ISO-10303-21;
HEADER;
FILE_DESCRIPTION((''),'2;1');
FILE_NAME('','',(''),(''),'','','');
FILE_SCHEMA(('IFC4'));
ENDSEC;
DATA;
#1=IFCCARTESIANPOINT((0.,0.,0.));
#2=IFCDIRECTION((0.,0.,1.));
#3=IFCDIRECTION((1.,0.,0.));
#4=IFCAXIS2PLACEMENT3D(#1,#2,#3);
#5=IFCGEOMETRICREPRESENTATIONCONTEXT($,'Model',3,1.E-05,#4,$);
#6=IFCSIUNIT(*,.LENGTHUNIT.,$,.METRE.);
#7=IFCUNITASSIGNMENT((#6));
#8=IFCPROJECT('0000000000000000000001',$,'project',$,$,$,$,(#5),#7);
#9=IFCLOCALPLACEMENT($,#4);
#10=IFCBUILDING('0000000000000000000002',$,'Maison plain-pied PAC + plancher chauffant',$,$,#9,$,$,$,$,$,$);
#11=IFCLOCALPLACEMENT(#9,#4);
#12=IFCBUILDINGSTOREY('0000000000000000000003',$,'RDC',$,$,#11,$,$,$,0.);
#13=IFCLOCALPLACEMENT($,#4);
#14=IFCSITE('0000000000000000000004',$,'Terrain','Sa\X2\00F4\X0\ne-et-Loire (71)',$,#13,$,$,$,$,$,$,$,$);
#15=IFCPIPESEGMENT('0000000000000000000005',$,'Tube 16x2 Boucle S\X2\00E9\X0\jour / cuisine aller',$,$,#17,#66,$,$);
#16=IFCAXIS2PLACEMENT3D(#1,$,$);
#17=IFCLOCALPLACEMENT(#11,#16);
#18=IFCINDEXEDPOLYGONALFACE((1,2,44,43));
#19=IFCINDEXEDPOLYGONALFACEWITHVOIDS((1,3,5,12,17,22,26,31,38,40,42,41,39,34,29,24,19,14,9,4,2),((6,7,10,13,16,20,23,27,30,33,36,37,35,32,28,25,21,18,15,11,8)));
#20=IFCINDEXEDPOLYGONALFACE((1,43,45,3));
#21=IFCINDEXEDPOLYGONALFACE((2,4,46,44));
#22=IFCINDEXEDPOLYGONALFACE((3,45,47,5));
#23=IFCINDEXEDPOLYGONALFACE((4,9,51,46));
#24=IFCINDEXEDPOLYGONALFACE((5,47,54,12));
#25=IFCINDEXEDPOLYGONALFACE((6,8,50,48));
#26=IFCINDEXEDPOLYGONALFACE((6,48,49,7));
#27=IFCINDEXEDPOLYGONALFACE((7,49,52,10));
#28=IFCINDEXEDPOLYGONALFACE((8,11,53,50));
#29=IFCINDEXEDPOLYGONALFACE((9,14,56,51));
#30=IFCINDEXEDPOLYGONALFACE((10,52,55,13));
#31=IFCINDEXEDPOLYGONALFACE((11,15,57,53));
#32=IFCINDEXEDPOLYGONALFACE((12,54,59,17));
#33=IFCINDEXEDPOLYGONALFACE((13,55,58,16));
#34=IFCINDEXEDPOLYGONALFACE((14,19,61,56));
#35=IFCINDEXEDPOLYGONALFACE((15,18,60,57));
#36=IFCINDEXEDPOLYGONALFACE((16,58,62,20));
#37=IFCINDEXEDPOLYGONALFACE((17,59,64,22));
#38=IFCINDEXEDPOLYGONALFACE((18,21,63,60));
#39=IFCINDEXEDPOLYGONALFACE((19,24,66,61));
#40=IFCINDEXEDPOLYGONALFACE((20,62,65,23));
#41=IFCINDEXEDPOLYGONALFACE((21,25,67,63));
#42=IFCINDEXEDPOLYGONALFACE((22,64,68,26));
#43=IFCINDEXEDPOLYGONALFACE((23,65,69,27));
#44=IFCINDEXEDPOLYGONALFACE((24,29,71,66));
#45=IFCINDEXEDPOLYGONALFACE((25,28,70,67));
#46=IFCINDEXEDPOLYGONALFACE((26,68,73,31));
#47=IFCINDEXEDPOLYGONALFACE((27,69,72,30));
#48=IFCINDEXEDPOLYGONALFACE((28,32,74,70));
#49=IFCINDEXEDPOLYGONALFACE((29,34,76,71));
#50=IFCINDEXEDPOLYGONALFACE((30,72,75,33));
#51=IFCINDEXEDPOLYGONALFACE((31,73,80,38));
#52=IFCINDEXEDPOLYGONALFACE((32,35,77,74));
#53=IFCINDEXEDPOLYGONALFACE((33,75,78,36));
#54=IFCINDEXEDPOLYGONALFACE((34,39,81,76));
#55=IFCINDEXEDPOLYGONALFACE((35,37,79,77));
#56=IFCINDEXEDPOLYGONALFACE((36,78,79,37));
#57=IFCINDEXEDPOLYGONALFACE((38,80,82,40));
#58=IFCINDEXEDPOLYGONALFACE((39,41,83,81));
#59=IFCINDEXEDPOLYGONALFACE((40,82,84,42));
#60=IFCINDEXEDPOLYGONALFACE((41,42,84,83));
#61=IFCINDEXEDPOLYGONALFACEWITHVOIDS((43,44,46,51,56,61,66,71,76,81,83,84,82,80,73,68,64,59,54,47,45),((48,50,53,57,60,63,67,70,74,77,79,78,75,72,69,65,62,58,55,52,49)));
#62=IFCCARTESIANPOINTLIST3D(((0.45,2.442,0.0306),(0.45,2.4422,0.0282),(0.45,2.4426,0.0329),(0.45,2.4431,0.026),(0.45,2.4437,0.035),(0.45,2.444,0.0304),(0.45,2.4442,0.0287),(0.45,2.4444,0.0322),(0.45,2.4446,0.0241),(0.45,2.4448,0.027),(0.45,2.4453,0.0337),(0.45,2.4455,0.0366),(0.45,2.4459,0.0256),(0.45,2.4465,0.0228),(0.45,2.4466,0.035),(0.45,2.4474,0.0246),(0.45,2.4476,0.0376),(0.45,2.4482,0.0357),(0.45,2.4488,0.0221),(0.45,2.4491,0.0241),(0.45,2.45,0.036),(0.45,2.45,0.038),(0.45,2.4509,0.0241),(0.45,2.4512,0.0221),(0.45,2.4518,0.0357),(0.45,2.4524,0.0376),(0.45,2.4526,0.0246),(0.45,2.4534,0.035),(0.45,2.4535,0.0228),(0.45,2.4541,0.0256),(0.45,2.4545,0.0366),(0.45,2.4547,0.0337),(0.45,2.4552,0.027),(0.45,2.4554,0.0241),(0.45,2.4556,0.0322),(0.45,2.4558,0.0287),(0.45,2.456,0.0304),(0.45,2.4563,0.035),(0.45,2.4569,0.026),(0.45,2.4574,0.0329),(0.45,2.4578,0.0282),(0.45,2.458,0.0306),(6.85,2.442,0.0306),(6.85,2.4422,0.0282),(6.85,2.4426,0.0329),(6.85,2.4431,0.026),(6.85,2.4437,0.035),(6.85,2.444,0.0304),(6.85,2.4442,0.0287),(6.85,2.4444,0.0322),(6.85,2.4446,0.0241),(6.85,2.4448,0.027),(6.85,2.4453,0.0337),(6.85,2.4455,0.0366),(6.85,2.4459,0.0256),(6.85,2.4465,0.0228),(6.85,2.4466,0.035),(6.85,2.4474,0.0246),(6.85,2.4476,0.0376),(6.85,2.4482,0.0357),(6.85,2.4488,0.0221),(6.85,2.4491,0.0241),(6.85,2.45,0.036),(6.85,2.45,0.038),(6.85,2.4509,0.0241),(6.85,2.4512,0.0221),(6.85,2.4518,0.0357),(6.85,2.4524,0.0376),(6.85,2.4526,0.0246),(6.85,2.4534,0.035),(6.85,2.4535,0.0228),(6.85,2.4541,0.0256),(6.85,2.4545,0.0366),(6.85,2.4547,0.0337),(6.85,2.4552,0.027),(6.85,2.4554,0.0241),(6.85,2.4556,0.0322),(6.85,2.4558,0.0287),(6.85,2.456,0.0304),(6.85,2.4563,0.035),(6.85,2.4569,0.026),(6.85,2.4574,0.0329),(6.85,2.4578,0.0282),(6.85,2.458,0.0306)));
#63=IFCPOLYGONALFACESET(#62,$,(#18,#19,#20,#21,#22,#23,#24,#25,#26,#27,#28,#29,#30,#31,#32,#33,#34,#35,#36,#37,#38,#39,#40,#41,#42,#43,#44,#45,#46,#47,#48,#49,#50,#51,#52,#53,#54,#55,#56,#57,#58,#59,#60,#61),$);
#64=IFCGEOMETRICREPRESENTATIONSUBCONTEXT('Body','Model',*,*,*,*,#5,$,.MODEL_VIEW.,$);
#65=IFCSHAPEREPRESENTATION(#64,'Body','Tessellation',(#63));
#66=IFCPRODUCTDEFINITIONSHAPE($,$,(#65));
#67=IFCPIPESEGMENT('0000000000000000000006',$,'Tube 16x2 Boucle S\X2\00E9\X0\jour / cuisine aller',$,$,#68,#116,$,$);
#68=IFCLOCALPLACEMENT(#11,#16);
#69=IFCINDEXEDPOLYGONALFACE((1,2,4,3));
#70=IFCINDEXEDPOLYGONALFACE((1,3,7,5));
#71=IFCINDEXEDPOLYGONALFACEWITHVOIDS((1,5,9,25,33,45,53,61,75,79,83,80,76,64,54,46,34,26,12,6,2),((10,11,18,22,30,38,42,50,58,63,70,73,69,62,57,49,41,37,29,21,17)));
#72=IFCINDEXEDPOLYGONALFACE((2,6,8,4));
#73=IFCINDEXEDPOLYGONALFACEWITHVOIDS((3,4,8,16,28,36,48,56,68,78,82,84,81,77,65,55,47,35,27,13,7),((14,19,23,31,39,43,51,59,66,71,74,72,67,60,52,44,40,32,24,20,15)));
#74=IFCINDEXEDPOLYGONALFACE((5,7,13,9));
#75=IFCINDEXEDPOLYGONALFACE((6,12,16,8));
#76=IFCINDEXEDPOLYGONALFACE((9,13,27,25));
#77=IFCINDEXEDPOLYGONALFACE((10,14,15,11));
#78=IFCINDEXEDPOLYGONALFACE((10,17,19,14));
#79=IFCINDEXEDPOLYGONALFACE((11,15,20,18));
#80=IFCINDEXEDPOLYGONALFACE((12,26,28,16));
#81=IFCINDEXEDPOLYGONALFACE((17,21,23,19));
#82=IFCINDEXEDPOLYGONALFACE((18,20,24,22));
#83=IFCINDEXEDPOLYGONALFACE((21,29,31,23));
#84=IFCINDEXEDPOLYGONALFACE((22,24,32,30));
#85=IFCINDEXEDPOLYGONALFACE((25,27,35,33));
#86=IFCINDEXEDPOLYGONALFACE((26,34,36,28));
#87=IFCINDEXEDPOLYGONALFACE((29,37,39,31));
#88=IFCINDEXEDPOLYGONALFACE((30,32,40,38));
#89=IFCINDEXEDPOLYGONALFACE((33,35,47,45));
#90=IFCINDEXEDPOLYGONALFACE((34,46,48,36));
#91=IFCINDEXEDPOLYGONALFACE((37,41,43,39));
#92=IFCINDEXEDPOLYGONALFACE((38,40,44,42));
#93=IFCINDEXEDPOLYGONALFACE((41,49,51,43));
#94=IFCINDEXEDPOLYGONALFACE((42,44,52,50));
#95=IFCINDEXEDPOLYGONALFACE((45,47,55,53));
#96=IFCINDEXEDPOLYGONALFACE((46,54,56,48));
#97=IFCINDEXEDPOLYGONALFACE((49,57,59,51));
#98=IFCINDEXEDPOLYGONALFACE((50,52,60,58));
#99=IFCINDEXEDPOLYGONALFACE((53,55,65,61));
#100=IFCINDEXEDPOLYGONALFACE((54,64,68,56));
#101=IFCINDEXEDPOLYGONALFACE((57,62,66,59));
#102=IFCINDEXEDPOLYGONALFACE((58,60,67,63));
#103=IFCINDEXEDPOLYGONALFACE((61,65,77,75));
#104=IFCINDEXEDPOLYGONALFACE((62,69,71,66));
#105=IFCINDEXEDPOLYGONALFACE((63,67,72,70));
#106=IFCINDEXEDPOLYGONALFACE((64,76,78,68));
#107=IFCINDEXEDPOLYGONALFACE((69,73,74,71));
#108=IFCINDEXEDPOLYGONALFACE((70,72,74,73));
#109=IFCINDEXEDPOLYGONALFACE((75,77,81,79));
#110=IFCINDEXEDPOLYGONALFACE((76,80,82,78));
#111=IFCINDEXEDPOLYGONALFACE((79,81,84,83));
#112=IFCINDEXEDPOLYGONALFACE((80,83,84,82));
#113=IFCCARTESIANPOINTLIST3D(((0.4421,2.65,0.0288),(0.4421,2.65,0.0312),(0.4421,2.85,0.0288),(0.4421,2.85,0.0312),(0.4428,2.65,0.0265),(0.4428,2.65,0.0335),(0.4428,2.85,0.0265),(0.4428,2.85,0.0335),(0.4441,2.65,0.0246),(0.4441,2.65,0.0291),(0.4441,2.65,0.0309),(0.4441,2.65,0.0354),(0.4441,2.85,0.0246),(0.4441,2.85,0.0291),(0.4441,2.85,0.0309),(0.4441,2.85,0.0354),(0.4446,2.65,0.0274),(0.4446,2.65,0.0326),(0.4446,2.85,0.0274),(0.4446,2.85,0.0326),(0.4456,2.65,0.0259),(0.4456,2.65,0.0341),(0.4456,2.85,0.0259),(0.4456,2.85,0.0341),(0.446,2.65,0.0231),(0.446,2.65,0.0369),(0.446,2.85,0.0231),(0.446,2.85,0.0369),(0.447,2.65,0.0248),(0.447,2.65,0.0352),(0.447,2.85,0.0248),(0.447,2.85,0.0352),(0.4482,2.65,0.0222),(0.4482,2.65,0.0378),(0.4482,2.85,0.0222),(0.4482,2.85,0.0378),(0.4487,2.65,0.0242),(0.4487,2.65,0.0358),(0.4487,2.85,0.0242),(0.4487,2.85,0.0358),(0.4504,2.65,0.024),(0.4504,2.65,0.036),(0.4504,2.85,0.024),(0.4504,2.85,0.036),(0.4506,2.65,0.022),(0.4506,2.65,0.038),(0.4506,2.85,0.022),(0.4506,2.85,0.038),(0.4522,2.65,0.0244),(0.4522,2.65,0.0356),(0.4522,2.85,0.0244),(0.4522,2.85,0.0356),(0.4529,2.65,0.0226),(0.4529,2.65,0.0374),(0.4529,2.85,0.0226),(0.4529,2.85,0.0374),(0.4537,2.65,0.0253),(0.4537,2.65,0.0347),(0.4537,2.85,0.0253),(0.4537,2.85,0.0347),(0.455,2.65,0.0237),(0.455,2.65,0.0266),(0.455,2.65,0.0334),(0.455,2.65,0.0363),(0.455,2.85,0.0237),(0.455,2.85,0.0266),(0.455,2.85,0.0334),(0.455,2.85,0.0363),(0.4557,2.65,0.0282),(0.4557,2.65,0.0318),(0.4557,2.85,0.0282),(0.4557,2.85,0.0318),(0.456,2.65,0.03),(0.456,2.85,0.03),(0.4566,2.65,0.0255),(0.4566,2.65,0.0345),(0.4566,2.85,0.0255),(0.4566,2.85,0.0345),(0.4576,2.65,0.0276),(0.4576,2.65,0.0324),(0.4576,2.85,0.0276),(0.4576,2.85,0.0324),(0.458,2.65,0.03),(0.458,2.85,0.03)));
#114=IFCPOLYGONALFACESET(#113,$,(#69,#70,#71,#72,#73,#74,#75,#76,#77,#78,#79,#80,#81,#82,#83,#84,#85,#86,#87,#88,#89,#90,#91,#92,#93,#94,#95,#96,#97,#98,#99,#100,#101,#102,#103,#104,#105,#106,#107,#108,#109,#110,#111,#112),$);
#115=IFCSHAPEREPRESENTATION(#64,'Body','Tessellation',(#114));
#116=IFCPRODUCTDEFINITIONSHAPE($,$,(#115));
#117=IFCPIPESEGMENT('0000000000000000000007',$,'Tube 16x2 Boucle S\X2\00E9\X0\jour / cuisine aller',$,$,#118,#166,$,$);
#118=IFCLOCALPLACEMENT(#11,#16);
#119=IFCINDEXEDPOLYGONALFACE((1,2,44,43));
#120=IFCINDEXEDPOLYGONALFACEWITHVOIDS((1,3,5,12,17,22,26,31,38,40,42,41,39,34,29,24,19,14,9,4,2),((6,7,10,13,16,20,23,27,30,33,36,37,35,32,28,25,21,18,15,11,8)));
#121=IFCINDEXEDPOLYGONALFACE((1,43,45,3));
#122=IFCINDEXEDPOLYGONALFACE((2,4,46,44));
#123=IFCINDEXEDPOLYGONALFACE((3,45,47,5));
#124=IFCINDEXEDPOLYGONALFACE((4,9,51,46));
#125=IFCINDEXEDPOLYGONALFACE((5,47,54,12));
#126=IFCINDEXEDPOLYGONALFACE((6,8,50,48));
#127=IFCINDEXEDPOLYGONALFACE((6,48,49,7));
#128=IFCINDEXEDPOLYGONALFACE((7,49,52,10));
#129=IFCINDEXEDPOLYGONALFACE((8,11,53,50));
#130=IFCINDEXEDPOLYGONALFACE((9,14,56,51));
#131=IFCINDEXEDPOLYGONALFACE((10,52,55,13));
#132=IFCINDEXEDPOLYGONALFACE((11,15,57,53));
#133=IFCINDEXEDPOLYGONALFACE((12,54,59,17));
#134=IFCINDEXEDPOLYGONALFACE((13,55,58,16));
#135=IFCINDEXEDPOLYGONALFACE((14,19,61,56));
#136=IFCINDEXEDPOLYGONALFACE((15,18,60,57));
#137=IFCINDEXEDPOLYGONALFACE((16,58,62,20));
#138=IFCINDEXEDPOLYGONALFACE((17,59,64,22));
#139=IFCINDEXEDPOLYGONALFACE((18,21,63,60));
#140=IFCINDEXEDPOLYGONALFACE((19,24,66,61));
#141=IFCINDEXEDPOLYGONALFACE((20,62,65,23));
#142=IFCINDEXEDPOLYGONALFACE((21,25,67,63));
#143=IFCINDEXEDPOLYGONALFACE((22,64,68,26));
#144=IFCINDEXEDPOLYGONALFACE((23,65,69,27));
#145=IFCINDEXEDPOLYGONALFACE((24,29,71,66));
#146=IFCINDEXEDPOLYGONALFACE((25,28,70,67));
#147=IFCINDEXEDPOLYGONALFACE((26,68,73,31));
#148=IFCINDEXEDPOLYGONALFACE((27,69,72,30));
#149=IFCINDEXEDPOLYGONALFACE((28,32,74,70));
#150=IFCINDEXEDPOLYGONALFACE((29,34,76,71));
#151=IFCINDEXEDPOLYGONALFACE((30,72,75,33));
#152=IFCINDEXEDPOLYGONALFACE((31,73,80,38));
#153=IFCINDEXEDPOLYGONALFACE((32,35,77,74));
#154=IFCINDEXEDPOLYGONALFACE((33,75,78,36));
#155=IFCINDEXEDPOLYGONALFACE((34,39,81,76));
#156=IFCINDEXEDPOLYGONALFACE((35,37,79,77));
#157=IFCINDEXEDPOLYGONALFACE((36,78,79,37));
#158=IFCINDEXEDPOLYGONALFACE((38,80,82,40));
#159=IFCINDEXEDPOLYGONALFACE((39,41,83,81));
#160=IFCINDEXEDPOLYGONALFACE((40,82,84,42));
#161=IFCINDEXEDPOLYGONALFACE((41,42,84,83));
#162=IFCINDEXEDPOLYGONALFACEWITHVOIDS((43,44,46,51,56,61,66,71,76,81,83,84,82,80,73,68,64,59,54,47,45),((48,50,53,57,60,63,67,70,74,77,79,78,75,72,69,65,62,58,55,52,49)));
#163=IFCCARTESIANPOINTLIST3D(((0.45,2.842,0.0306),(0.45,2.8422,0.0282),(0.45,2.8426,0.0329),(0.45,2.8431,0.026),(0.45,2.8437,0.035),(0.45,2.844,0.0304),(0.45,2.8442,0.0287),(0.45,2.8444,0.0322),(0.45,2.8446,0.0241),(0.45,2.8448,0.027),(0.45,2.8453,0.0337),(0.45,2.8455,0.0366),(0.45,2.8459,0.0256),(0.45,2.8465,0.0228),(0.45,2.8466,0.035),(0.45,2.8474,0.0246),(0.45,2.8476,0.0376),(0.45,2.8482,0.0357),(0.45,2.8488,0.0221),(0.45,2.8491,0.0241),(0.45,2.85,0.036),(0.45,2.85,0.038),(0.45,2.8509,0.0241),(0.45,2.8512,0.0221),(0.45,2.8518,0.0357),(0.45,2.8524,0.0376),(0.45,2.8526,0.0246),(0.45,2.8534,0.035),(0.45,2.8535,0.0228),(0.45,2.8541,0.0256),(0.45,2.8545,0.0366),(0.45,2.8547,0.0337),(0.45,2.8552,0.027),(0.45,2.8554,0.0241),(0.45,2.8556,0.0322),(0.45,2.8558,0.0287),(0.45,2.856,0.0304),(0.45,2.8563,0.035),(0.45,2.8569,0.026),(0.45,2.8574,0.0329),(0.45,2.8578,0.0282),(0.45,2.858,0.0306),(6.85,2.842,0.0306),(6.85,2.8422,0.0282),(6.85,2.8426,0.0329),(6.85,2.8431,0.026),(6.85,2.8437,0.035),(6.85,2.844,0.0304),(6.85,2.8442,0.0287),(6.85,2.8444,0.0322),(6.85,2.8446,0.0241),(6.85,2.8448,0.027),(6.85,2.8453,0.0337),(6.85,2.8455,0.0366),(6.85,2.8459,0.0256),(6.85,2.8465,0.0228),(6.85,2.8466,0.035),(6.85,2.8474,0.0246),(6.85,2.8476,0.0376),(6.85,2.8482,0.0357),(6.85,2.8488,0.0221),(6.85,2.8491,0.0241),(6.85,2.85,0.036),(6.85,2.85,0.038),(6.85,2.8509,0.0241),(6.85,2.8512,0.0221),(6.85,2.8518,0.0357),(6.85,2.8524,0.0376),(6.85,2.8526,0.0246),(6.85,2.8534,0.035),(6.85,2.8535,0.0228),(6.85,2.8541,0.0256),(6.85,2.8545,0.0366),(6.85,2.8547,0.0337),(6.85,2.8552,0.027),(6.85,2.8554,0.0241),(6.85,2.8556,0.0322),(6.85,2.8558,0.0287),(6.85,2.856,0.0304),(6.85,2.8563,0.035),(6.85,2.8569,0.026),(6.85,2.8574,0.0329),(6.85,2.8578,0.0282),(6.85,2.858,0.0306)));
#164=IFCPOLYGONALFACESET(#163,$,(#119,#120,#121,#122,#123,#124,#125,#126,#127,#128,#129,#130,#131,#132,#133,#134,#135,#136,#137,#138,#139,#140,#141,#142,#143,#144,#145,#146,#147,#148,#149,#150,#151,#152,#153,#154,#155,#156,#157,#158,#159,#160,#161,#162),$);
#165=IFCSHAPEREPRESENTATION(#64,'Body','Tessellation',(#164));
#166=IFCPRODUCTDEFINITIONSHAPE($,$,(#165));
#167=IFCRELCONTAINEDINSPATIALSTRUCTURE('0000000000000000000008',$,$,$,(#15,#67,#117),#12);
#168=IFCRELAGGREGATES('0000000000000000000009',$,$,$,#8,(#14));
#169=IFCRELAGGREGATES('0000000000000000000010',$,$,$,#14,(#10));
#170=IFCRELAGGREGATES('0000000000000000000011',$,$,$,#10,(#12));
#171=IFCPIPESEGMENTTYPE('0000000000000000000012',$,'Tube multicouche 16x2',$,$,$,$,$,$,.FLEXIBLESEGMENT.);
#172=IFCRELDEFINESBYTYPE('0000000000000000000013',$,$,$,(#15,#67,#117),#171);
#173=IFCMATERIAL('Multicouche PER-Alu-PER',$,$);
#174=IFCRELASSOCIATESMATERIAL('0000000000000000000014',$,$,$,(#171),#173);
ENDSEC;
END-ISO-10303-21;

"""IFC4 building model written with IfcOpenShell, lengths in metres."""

from ifc_helpers import new_model, si_unit, frame, origin_with_axes, place, context, subcontext, project, spatial, hollow_circle, extrude, material, type_object, element, save


model = new_model("IFC4")

# Units and contexts
model_context = context("Model", 3, precision=1e-05, world=origin_with_axes())
body_context = subcontext(model_context, "Body", "Model", "MODEL_VIEW")
ifc_project = project(units=[si_unit("LENGTHUNIT", "METRE")], contexts=[model_context])

# Site, building, storey
site_placement = place(None, origin_with_axes())
site = spatial("IfcSite", under=ifc_project, at=site_placement, Name="Terrain", Description="Saône-et-Loire (71)")
building_placement = place(None, origin_with_axes())
building = spatial("IfcBuilding", under=site, at=building_placement, Name="Maison plain-pied PAC + plancher chauffant")
storey_placement = place(building_placement, origin_with_axes())
storey = spatial("IfcBuildingStorey", under=building, at=storey_placement, Name="RDC", Elevation=0.0)

# Pipe segments
ifc_material = material(Name="Multicouche PER-Alu-PER")
pipe_segment_type = type_object("IfcPipeSegmentType", Name="Tube multicouche 16x2", PredefinedType="FLEXIBLESEGMENT", material=ifc_material)
pipe_segment_1_placement = place(storey_placement, frame((0.45, 2.45, 0.03), z_axis=(1.0, 0.0, 0.0), x_axis=(0.0, 0.0, 1.0)))
element("IfcPipeSegment", 1, at=pipe_segment_1_placement, inside=storey, type_object=pipe_segment_type, Name="Tube 16x2 Boucle Séjour / cuisine aller", context=body_context, shape_type="SweptSolid", body=[
    extrude(hollow_circle(Radius=0.008, WallThickness=0.002), origin_with_axes(), (0.0, 0.0, 1.0), 6.4),
])
pipe_segment_2_placement = place(storey_placement, frame((0.45, 2.65, 0.03), z_axis=(0.0, 1.0, 0.0), x_axis=(1.0, 0.0, 0.0)))
element("IfcPipeSegment", 2, at=pipe_segment_2_placement, inside=storey, type_object=pipe_segment_type, Name="Tube 16x2 Boucle Séjour / cuisine aller", context=body_context, shape_type="SweptSolid", body=[
    extrude(hollow_circle(Radius=0.008, WallThickness=0.002), origin_with_axes(), (0.0, 0.0, 1.0), 0.2),
])
pipe_segment_3_placement = place(storey_placement, frame((0.45, 2.85, 0.03), z_axis=(1.0, 0.0, 0.0), x_axis=(0.0, 0.0, 1.0)))
element("IfcPipeSegment", 3, at=pipe_segment_3_placement, inside=storey, type_object=pipe_segment_type, Name="Tube 16x2 Boucle Séjour / cuisine aller", context=body_context, shape_type="SweptSolid", body=[
    extrude(hollow_circle(Radius=0.008, WallThickness=0.002), origin_with_axes(), (0.0, 0.0, 1.0), 6.4),
])

save(model, "model.ifc")
